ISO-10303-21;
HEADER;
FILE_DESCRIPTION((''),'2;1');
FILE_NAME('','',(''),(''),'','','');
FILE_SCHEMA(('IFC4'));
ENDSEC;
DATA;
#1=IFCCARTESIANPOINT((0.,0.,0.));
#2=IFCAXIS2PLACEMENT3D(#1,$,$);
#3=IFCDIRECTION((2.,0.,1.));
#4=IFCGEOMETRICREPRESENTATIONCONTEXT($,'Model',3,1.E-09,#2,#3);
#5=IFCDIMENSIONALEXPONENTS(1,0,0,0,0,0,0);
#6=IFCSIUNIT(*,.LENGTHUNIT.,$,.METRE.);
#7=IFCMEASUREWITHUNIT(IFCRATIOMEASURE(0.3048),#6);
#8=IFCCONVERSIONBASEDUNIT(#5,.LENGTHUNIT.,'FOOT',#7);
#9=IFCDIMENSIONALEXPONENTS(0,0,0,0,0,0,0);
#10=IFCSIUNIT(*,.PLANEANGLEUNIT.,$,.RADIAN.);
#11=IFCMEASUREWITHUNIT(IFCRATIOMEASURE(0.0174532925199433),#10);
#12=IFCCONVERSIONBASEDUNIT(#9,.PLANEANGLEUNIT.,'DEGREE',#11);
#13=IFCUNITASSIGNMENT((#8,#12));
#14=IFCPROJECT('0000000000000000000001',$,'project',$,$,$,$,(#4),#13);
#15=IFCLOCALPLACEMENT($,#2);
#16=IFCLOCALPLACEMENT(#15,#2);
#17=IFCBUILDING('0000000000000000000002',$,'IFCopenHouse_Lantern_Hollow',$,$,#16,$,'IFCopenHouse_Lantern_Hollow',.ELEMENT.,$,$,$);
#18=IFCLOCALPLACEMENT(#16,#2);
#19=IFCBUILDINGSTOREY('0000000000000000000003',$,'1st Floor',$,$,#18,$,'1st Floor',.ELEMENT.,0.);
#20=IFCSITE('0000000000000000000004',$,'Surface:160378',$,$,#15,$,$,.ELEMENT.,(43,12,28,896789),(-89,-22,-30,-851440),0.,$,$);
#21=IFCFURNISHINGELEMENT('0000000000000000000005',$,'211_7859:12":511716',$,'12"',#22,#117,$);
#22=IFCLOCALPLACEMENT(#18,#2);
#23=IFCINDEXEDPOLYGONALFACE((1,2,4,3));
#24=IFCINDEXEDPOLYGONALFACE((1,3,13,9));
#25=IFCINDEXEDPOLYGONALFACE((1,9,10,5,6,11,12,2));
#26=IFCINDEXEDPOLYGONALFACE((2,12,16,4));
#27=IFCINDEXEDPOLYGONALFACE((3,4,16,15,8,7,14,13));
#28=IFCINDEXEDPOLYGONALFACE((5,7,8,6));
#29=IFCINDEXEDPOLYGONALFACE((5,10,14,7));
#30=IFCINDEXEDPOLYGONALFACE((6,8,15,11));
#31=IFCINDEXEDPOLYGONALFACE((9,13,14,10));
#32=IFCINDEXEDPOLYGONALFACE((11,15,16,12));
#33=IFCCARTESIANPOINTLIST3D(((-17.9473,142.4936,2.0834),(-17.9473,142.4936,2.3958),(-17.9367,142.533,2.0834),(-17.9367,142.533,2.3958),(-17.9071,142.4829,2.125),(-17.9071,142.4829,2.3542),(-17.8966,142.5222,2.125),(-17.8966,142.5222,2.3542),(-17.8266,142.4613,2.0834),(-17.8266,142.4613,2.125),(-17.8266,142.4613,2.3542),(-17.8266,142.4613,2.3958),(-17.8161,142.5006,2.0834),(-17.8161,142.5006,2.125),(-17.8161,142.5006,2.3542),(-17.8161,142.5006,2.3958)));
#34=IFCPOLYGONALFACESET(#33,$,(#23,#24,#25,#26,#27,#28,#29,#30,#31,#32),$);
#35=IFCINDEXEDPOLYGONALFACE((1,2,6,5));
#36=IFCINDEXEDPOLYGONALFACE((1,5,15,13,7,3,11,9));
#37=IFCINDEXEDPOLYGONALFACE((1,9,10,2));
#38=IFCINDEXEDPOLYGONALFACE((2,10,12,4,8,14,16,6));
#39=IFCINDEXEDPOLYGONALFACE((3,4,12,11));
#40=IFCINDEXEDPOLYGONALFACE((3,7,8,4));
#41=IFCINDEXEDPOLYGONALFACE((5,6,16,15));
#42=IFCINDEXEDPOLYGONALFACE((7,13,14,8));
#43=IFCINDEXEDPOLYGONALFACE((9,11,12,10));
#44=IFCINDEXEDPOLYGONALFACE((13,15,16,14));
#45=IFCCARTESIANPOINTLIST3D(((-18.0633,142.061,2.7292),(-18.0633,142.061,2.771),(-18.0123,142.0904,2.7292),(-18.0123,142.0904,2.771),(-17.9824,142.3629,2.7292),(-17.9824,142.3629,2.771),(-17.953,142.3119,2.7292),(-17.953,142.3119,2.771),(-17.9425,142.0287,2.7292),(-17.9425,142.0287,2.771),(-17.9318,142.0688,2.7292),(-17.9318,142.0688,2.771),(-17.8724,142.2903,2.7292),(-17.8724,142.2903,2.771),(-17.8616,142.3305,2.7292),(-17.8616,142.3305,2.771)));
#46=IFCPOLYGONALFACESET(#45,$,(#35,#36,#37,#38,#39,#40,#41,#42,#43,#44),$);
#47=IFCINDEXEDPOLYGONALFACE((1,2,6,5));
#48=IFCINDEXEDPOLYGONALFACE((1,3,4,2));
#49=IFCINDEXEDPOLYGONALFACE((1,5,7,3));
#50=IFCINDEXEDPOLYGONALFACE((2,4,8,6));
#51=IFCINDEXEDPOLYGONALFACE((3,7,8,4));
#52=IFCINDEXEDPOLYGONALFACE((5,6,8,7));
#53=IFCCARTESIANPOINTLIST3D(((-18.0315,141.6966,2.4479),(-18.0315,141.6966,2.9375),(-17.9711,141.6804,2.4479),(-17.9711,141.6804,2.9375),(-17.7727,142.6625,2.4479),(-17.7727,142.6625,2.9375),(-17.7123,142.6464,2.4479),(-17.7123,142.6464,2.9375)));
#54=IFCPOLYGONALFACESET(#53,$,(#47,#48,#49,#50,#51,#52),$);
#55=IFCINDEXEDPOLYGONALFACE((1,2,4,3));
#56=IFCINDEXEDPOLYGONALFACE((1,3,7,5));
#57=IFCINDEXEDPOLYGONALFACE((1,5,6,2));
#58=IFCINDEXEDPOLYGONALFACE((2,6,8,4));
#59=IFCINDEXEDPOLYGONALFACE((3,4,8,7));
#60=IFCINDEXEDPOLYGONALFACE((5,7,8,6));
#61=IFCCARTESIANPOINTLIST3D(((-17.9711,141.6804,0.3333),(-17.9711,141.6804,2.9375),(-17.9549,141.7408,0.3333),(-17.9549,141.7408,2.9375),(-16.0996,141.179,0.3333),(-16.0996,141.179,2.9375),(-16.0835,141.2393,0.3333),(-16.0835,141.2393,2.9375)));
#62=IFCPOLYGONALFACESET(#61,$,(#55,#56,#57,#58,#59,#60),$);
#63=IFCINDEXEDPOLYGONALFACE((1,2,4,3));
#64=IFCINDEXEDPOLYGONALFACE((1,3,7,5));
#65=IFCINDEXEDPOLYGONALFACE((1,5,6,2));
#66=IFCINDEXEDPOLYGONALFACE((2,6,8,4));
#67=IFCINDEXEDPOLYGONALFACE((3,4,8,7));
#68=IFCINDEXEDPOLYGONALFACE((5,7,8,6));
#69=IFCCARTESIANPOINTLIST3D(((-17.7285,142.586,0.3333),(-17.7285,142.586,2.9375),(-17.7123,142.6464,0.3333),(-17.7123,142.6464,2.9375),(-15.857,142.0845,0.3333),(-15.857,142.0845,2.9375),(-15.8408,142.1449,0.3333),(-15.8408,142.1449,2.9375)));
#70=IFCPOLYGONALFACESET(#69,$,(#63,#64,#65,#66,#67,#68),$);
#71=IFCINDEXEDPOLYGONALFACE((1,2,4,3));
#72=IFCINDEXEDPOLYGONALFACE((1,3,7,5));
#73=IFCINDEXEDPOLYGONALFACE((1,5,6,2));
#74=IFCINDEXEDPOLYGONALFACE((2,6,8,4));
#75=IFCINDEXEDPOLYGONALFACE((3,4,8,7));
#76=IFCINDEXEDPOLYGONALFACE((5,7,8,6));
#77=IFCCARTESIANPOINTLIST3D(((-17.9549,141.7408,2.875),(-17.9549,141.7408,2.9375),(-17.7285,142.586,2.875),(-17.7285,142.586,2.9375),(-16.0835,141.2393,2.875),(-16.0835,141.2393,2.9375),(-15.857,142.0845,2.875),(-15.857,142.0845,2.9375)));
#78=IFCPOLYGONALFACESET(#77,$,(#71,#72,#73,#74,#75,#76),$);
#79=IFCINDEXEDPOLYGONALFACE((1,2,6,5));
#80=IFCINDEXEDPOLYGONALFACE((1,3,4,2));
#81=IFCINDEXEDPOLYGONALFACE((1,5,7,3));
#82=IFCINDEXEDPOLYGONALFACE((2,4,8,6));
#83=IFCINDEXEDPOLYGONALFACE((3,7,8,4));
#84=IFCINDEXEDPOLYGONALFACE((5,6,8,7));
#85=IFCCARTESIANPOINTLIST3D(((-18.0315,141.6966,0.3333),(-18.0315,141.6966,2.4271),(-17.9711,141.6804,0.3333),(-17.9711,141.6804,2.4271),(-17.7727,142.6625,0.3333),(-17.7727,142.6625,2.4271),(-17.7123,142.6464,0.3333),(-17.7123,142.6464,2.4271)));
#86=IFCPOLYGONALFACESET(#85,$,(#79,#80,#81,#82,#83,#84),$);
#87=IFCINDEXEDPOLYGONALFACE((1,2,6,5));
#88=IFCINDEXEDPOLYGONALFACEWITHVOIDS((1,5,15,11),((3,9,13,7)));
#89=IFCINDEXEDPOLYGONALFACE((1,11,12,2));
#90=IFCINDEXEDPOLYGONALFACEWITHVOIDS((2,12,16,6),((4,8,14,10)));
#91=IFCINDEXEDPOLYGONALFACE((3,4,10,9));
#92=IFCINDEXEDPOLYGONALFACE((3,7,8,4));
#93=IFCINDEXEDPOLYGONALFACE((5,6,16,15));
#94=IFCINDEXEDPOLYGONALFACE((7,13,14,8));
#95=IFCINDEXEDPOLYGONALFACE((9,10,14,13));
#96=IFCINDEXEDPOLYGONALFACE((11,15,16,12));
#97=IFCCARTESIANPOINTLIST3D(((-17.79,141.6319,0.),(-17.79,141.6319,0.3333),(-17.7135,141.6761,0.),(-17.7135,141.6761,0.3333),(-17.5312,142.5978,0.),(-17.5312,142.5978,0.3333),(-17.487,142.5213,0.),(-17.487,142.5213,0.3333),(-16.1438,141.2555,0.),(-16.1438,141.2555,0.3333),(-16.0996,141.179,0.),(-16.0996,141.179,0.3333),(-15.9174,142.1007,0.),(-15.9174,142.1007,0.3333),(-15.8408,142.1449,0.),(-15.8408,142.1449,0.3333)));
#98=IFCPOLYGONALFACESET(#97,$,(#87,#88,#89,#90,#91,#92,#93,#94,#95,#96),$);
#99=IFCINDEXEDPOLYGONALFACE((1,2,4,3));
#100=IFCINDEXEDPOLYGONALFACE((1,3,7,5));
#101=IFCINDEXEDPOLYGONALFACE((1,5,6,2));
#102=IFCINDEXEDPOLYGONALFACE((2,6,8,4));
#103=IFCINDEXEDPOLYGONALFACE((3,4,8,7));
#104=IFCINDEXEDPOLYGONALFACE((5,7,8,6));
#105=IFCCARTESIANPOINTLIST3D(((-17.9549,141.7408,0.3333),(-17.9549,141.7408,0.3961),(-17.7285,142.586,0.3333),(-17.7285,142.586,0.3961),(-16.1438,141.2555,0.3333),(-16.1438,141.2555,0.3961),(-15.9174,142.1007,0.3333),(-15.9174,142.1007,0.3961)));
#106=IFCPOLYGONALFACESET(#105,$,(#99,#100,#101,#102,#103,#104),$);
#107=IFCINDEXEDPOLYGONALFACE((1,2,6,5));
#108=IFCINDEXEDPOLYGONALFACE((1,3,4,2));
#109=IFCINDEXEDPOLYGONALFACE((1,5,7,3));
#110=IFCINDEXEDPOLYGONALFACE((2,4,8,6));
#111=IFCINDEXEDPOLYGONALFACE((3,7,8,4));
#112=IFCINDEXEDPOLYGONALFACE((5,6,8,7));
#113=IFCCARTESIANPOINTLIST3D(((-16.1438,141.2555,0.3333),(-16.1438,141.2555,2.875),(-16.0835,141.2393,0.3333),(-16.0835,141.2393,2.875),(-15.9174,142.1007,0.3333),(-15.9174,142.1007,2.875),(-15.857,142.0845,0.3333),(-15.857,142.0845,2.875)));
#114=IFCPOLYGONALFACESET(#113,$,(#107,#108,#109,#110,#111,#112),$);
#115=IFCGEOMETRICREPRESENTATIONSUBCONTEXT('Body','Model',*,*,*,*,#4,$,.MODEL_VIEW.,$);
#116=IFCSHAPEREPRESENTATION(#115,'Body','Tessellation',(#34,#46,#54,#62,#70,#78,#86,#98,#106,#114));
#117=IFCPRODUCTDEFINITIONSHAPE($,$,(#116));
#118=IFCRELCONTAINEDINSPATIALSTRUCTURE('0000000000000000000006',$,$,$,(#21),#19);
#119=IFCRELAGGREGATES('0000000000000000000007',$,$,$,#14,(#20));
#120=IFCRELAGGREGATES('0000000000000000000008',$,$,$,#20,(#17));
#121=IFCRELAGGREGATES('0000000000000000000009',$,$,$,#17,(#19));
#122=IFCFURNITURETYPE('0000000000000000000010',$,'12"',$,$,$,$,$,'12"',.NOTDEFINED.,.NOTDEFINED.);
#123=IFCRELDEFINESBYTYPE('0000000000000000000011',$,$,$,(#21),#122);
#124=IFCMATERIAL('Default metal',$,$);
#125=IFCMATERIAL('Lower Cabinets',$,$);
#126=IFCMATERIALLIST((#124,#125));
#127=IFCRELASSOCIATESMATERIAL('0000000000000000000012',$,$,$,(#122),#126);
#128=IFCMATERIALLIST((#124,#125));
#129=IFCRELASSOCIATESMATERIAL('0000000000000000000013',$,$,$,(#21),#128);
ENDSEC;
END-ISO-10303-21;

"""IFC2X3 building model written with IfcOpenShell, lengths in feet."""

from ifc_helpers import new_model, entity, si_unit, converted_unit, direction, frame, frame_2d, origin, origin_2d_with_axis, place, context, subcontext, project, spatial, polyline, rectangle, outline, extrude, source, transform, mapped, material, material_list, type_object, type_shapes, element, save


model = new_model("IFC2X3")

# Units and contexts
model_context = context("Model", 3, precision=1e-09, world=origin(), true_north=direction((2.0, 0.0, 1.0)))
body_context = subcontext(model_context, "Body", "Model", "MODEL_VIEW")
ifc_project = project(units=[converted_unit("LENGTHUNIT", "FOOT", entity("IfcRatioMeasure", 0.3048), si_unit("LENGTHUNIT", "METRE"), dimensions=[1, 0, 0, 0, 0, 0, 0]), converted_unit("PLANEANGLEUNIT", "DEGREE", entity("IfcRatioMeasure", 0.0174532925199433), si_unit("PLANEANGLEUNIT", "RADIAN"), dimensions=[0, 0, 0, 0, 0, 0, 0])], contexts=[model_context])

# Site, building, storey
site_placement = place(None, origin())
site = spatial("IfcSite", under=ifc_project, at=site_placement, Name="Surface:160378", CompositionType="ELEMENT", RefLatitude=(43, 12, 28, 896789), RefLongitude=(-89, -22, -30, -851440), RefElevation=0.0)
building_placement = place(site_placement, origin())
building = spatial("IfcBuilding", under=site, at=building_placement, Name="IFCopenHouse_Lantern_Hollow", LongName="IFCopenHouse_Lantern_Hollow", CompositionType="ELEMENT")
storey_placement = place(building_placement, origin())
storey = spatial("IfcBuildingStorey", under=building, at=storey_placement, Name="1st Floor", LongName="1st Floor", CompositionType="ELEMENT", Elevation=0.0)

# Furnishing element
ifc_material_1 = material(Name="Default metal")
ifc_material_2 = material(Name="Lower Cabinets")
ifc_material_list_1 = material_list([ifc_material_1, ifc_material_2])
ifc_material_list_2 = material_list([ifc_material_1, ifc_material_2])
furniture_type_1 = type_object("IfcFurnitureType", Name="12\"", ElementType="12\"", AssemblyPlace="NOTDEFINED", material=ifc_material_list_2)
shared_shape_1 = source(origin(), body_context, "Body", "SweptSolid", [
    extrude(outline(polyline([(-0.0521, -0.1146), (-0.0521, -0.1562), (0.0729, -0.1562), (0.0729, 0.1562), (-0.0521, 0.1562), (-0.0521, 0.1146), (0.0313, 0.1146), (0.0313, -0.1146), (-0.0521, -0.1146)])), frame((-0.1469, 2.0521, 2.2396), z_axis=(-1.0, 0.0, 0.0), x_axis=(0.0, 1.0, 0.0)), (0.0, 0.0, -1.0), 0.0407),
    extrude(outline(polyline([(-0.1562, -0.0521), (-0.1146, -0.0521), (-0.1146, 0.0313), (0.1146, 0.0313), (0.1146, -0.0521), (0.1562, -0.0521), (0.1562, 0.0729), (-0.1562, 0.0729), (-0.1562, -0.0521)])), frame((-0.4385, 2.0521, 2.7292)), (0.0, 0.0, 1.0), 0.0418),
    extrude(rectangle(XDim=1.0, YDim=0.0625, at=frame_2d((0.0, 0.0), x_axis=(1.0, 0.0))), frame((-0.4385, 1.9688, 2.4479), z_axis=(0.0, 0.0, 1.0), x_axis=(-1.0, 0.0, 0.0)), (0.0, 0.0, 1.0), 0.4896),
    extrude(rectangle(XDim=1.9375, YDim=0.0625, at=origin_2d_with_axis()), frame((-0.9073, 0.9687, 0.3333), z_axis=(0.0, 0.0, 1.0), x_axis=(0.0, -1.0, 0.0)), (0.0, 0.0, 1.0), 2.6042),
    extrude(rectangle(XDim=1.9375, YDim=0.0625, at=frame_2d((0.0, 0.0), x_axis=(1.0, 0.0))), frame((0.0302, 0.9687, 0.3333), z_axis=(0.0, 0.0, 1.0), x_axis=(0.0, -1.0, 0.0)), (0.0, 0.0, 1.0), 2.6042),
    extrude(rectangle(XDim=1.9375, YDim=0.875, at=frame_2d((0.0, 0.0), x_axis=(1.0, 0.0))), frame((-0.4385, 0.9687, 2.875), z_axis=(0.0, 0.0, 1.0), x_axis=(0.0, 1.0, 0.0)), (0.0, 0.0, 1.0), 0.0625),
    extrude(rectangle(XDim=1.0, YDim=0.0625, at=frame_2d((0.0, 0.0), x_axis=(1.0, 0.0))), frame((-0.4385, 1.9688, 0.3333), z_axis=(0.0, 0.0, 1.0), x_axis=(-1.0, 0.0, 0.0)), (0.0, 0.0, 1.0), 2.0938),
    extrude(outline(polyline([(-0.875, -0.5), (0.875, -0.5), (0.875, 0.5), (-0.875, 0.5), (-0.875, -0.5)]), holes=[polyline([(-0.8125, -0.4375), (-0.8125, 0.4375), (0.8125, 0.4375), (0.8125, -0.4375), (-0.8125, -0.4375)])]), frame((-0.4385, 0.875, 0.0), z_axis=(0.0, 0.0, 1.0), x_axis=(0.0, -1.0, 0.0)), (0.0, 0.0, 1.0), 0.3333),
    extrude(rectangle(XDim=1.875, YDim=0.875, at=origin_2d_with_axis()), frame((-0.4385, 1.0, 0.3333), z_axis=(0.0, 0.0, 1.0), x_axis=(0.0, 1.0, 0.0)), (0.0, 0.0, 1.0), 0.0627),
    extrude(rectangle(XDim=0.875, YDim=0.0625, at=origin_2d_with_axis()), frame((-0.4385, 0.0312, 0.3333), z_axis=(0.0, 0.0, 1.0), x_axis=(-1.0, 0.0, 0.0)), (0.0, 0.0, 1.0), 2.5417),
])
type_shapes(furniture_type_1, [shared_shape_1])
furnishing_1_placement = place(storey_placement, frame((-15.8567, 142.0855, 0.0), z_axis=(0.0, 0.0, 1.0), x_axis=(0.258819, 0.965926, 0.0)))
element("IfcFurnishingElement", 1, at=furnishing_1_placement, inside=storey, type_object=furniture_type_1, material=ifc_material_list_1, Name="211_7859:12\":511716", ObjectType="12\"", context=body_context, shape_type="MappedRepresentation", body=[
    mapped(shared_shape_1, transform((0.0, 0.0, 0.0), scale=1.0)),
])

save(model, "model.ifc")
